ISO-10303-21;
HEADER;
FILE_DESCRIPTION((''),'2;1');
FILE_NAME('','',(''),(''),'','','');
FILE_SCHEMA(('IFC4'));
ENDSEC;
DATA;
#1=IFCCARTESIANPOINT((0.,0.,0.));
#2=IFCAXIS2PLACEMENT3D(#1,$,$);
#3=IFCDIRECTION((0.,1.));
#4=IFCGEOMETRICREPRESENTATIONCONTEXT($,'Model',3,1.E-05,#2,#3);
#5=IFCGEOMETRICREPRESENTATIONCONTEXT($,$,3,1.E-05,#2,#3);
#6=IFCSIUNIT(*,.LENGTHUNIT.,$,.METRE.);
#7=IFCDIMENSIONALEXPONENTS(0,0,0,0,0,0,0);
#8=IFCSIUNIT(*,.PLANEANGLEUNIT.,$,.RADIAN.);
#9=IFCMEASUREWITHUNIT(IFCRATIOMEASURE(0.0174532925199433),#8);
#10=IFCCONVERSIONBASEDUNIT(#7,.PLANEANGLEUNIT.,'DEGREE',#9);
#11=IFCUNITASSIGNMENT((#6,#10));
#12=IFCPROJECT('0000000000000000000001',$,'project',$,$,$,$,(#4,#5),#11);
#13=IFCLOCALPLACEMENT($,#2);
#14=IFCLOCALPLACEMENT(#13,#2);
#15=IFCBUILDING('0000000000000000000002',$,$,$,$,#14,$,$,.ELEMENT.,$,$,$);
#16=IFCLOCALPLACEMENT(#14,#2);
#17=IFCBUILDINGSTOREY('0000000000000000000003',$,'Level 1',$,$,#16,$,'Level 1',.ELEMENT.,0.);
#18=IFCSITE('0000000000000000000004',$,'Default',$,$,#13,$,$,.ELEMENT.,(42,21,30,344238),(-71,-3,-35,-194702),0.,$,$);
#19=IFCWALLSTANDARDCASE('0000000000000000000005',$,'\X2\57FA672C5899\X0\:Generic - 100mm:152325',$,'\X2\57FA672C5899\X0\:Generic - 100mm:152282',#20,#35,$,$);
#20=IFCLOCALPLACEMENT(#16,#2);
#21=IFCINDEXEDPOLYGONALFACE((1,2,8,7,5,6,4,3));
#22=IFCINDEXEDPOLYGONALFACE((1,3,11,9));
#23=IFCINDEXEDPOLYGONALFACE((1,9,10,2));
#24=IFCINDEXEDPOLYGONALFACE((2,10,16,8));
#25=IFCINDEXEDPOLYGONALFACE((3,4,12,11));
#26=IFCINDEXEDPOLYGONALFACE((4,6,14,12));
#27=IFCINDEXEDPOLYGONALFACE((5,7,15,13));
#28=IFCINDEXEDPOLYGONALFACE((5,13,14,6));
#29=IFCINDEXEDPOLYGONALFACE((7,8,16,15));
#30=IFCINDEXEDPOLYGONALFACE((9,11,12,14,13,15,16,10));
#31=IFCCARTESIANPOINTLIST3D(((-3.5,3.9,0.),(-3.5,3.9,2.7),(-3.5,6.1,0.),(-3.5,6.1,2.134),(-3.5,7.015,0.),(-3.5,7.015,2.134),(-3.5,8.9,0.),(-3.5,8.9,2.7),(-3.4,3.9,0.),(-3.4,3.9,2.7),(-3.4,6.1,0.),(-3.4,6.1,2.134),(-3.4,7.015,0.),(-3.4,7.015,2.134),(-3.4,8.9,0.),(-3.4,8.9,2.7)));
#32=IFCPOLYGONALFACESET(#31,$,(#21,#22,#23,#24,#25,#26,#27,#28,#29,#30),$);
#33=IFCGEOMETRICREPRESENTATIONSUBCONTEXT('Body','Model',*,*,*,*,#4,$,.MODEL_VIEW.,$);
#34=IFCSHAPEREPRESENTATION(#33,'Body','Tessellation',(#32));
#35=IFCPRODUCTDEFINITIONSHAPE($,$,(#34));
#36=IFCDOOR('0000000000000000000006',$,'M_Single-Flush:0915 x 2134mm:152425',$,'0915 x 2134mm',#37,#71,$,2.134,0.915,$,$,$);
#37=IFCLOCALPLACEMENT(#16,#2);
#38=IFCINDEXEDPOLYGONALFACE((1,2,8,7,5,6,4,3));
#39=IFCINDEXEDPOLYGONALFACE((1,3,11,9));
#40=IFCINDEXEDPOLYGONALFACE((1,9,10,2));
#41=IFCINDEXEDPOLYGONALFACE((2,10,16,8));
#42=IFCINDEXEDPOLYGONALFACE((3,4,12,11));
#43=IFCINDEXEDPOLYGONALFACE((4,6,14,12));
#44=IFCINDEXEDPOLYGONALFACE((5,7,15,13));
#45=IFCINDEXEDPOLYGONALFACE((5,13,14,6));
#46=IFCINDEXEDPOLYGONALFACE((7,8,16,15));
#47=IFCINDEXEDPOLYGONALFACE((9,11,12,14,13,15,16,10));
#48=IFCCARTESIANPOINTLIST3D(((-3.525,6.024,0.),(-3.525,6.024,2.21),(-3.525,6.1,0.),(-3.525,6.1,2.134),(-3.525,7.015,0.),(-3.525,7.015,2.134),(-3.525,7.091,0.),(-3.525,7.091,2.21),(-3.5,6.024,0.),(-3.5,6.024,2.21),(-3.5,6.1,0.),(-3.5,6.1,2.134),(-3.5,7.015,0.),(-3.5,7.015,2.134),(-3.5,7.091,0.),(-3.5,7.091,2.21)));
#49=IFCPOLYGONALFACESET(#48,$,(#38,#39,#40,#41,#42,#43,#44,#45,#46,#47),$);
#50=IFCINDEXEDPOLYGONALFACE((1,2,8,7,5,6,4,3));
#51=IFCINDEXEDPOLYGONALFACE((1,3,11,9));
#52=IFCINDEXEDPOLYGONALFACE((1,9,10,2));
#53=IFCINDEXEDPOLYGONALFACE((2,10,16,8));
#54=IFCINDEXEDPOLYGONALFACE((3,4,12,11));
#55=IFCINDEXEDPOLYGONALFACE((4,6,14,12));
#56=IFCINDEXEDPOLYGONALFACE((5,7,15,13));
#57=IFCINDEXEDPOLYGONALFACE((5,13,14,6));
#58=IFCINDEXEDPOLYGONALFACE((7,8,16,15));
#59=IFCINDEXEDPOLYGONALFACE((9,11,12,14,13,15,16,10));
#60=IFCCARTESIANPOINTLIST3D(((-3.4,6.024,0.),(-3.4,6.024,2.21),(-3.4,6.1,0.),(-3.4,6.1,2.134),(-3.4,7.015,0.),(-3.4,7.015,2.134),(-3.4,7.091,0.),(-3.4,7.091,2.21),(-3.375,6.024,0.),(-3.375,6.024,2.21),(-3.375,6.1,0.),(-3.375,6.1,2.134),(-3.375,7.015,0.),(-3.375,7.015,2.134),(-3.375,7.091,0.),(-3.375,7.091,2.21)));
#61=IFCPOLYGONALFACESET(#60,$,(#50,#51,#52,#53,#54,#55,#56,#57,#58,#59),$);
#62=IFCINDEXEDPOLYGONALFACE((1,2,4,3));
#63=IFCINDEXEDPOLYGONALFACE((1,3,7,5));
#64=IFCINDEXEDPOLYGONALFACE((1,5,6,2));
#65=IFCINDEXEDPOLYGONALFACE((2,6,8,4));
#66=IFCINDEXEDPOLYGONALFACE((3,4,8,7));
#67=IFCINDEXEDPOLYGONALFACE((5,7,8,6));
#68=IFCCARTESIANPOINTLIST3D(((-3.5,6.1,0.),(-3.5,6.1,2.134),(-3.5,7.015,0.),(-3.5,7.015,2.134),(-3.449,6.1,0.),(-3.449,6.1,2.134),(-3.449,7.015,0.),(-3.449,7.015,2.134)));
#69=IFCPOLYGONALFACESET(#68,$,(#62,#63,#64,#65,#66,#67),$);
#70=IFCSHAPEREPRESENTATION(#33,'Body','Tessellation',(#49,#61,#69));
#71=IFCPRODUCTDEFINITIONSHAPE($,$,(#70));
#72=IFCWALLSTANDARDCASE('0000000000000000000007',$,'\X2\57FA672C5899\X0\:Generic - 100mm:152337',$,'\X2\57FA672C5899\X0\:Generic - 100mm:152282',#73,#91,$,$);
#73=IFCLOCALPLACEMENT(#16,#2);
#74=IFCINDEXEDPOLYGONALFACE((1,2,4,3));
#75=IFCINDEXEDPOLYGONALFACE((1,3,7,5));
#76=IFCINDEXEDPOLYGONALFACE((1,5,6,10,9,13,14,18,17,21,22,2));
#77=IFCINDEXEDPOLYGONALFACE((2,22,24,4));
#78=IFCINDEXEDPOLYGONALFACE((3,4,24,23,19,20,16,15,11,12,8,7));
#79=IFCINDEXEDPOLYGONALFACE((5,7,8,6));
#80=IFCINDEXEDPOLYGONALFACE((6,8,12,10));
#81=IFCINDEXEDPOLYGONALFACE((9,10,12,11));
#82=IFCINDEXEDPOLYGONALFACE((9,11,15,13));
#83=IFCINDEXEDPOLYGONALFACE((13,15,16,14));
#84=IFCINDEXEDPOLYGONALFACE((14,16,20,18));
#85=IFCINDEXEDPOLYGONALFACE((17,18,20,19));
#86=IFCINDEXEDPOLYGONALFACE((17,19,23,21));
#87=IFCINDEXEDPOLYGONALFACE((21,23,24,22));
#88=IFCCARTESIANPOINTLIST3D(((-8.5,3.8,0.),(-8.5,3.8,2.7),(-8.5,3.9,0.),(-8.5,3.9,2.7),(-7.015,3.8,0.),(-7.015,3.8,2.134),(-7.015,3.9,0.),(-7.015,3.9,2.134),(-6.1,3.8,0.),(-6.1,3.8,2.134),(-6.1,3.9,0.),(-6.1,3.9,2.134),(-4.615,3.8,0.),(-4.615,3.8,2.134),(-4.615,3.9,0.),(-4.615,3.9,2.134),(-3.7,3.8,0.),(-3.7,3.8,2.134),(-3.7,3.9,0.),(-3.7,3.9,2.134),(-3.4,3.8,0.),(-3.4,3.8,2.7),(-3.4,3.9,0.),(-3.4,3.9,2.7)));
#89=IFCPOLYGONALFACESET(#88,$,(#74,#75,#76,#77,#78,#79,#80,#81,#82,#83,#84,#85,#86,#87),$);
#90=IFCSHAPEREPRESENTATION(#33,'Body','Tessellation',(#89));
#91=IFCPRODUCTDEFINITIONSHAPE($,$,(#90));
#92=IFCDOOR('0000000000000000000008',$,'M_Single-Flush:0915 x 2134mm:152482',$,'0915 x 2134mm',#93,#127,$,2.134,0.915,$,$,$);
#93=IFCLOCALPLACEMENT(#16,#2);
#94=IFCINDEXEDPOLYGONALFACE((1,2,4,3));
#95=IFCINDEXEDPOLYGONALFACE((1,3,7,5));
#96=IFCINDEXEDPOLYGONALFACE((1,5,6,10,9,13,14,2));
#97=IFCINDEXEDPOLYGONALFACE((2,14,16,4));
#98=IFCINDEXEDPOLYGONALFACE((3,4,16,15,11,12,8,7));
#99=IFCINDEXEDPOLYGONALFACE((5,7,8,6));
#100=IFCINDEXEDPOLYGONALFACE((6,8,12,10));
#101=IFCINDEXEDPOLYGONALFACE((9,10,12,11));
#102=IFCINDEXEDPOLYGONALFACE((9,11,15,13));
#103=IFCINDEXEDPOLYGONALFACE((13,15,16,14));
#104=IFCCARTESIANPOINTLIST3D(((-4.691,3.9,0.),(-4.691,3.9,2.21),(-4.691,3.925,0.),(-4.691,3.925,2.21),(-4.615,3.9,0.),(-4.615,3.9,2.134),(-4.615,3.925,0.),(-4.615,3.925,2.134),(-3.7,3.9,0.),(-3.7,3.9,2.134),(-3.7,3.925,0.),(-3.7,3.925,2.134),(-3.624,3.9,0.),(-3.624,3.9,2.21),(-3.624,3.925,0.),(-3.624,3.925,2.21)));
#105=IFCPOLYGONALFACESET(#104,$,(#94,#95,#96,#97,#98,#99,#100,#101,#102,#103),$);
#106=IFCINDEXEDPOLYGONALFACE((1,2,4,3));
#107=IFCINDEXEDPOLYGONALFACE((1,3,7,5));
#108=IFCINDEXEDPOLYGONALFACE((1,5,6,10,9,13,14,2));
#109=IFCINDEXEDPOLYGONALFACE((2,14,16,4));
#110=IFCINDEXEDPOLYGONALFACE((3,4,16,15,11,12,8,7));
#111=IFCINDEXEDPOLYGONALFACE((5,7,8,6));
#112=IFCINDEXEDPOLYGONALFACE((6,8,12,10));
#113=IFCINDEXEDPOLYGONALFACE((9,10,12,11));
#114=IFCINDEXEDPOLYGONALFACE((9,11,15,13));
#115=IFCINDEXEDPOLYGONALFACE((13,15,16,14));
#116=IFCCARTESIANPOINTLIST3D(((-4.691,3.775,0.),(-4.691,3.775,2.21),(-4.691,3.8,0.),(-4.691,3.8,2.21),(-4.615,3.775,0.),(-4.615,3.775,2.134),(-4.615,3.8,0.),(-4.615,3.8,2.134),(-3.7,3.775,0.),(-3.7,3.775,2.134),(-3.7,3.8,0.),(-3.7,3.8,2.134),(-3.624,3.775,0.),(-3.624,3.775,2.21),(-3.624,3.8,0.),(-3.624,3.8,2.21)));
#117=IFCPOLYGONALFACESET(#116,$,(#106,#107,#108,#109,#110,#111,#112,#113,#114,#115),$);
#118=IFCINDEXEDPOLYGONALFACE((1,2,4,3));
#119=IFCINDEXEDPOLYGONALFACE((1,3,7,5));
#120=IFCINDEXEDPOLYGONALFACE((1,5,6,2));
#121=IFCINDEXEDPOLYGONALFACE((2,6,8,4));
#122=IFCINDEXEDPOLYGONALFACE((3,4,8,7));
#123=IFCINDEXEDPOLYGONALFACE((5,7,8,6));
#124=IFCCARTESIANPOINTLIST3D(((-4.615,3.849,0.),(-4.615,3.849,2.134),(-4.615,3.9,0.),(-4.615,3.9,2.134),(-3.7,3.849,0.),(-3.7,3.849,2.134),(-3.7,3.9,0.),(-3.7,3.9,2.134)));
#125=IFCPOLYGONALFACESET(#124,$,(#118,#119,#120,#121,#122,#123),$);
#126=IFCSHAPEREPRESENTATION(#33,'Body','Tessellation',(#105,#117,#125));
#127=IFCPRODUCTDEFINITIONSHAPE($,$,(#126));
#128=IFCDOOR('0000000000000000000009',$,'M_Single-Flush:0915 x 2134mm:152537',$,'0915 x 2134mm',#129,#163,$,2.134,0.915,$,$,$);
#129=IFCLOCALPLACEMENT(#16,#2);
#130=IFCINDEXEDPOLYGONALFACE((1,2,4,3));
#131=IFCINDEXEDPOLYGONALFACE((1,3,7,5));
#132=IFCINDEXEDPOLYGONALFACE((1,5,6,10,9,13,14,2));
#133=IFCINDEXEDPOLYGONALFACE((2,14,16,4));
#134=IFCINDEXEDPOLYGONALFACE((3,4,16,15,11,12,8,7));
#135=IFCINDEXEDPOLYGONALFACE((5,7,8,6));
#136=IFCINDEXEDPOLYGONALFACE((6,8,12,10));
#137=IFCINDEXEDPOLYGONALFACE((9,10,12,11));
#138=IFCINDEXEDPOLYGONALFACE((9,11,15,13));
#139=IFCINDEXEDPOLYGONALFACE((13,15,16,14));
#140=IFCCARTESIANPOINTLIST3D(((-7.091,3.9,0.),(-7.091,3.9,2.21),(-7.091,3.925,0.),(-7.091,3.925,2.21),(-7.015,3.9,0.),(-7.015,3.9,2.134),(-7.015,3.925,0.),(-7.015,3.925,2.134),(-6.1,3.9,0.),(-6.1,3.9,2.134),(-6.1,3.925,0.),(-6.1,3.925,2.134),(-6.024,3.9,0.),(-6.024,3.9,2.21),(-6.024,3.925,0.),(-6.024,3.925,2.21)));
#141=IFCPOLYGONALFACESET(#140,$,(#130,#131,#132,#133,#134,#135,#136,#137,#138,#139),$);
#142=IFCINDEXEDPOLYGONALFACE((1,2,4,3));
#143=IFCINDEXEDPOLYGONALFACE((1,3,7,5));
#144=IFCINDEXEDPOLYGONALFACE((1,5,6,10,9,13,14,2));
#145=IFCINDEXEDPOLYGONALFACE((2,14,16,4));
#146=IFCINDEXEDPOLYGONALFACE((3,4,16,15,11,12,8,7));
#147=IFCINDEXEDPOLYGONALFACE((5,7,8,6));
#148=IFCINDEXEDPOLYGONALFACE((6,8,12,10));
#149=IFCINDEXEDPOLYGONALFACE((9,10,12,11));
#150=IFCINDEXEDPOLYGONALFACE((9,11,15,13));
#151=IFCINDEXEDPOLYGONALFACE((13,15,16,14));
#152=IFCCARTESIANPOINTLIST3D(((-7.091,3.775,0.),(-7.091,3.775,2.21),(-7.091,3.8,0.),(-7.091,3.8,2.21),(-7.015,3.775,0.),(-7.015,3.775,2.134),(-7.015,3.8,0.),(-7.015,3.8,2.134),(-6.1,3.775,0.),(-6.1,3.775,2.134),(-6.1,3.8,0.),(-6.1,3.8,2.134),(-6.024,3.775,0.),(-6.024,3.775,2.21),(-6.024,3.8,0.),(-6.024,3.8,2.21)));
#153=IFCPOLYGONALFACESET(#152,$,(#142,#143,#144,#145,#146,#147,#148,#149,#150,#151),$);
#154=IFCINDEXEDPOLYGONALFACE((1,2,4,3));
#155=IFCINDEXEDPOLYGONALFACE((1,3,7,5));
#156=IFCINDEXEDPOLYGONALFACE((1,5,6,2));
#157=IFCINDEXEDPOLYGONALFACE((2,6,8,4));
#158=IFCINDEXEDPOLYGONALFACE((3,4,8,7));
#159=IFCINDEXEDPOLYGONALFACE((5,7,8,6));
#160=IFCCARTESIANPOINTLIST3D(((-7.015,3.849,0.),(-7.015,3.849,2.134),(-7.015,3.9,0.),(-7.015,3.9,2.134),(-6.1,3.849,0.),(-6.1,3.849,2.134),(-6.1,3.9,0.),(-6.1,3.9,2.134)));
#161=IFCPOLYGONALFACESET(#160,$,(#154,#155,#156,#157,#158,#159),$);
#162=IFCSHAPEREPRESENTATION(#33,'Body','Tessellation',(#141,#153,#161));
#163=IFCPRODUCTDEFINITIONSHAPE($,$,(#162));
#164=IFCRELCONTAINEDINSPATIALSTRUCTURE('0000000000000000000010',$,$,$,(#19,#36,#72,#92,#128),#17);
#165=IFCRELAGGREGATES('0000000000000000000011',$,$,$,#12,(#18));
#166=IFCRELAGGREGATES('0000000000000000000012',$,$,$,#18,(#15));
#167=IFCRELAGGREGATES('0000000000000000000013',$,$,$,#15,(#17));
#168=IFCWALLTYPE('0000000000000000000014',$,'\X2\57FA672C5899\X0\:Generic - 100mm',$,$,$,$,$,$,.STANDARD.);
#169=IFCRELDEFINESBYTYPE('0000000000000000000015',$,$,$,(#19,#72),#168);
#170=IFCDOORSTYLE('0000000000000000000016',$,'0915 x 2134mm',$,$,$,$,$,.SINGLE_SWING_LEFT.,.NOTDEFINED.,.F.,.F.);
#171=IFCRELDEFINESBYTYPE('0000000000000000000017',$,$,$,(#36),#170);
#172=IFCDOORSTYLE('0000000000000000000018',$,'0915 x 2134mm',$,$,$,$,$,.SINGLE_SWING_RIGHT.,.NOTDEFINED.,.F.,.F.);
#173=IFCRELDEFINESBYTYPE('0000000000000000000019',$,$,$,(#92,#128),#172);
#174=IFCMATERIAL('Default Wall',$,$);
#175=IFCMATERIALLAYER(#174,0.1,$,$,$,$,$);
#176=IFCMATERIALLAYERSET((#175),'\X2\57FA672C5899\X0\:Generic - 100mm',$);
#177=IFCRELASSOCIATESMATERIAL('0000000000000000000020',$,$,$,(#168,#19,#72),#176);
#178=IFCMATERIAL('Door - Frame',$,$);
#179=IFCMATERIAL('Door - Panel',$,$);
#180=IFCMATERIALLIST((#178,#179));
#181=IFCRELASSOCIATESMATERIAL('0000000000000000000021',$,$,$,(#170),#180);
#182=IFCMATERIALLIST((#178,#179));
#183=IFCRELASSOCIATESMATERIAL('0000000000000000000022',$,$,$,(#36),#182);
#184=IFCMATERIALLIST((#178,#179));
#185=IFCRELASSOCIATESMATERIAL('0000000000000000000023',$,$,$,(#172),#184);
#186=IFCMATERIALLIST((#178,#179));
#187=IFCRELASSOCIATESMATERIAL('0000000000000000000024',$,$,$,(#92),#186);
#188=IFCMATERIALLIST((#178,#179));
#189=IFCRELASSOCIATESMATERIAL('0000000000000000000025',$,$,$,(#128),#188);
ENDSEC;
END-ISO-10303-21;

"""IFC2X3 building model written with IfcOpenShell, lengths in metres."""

from ifc_helpers import new_model, entity, si_unit, converted_unit, direction, frame, frame_2d, origin, origin_2d_with_axis, place, context, subcontext, project, spatial, polyline, rectangle, outline, extrude, clip, bounded_halfspace, source, transform, mapped, material, material_list, layer, layer_set, layer_usage, type_object, type_shapes, element, fill, save


model = new_model("IFC2X3")

# Units and contexts
model_context = context("Model", 3, precision=1e-05, world=origin(), true_north=direction((0.0, 1.0)))
context_of_model = context(None, 3, precision=1e-05, world=origin(), true_north=direction((0.0, 1.0)))
body_context = subcontext(model_context, "Body", "Model", "MODEL_VIEW")
ifc_project = project(units=[si_unit("LENGTHUNIT", "METRE"), converted_unit("PLANEANGLEUNIT", "DEGREE", entity("IfcRatioMeasure", 0.0174532925199433), si_unit("PLANEANGLEUNIT", "RADIAN"), dimensions=[0, 0, 0, 0, 0, 0, 0])], contexts=[model_context, context_of_model])

# Site, building, storey
site_placement = place(None, origin())
site = spatial("IfcSite", under=ifc_project, at=site_placement, Name="Default", CompositionType="ELEMENT", RefLatitude=(42, 21, 30, 344238), RefLongitude=(-71, -3, -35, -194702), RefElevation=0.0)
building_placement = place(site_placement, origin())
building = spatial("IfcBuilding", under=site, at=building_placement, CompositionType="ELEMENT")
storey_placement = place(building_placement, origin())
storey = spatial("IfcBuildingStorey", under=building, at=storey_placement, Name="Level 1", LongName="Level 1", CompositionType="ELEMENT", Elevation=0.0)

# Wall, opening, door
ifc_material_1 = material(Name="Default Wall")
ifc_layer_1 = layer(ifc_material_1, 0.1)
ifc_layer_set_1 = layer_set([ifc_layer_1], Name="基本墙:Generic - 100mm")
ifc_layer_usage_1 = layer_usage(ifc_layer_set_1, "AXIS2", "NEGATIVE", 0.05)
wall_type_1 = type_object("IfcWallType", Name="基本墙:Generic - 100mm", PredefinedType="STANDARD", material=ifc_layer_set_1)
wall_1_placement = place(storey_placement, frame((-3.45, 8.9, 0.0), z_axis=(0.0, 0.0, 1.0), x_axis=(0.0, -1.0, 0.0)))
wall_1 = element("IfcWallStandardCase", 1, at=wall_1_placement, inside=storey, type_object=wall_type_1, material=ifc_layer_usage_1, Name="基本墙:Generic - 100mm:152325", ObjectType="基本墙:Generic - 100mm:152282", context=body_context, shape_type="Clipping", body=[
    clip(extrude(rectangle(XDim=5.0, YDim=0.1, at=frame_2d((2.5, 0.0), x_axis=(-1.0, 0.0))), origin(), (0.0, 0.0, 1.0), 3.0), bounded_halfspace(frame((0.0, -0.05, 2.7), z_axis=(0.0, 0.0, -1.0), x_axis=(1.0, 0.0, 0.0)), True, frame((0.0, -0.05, 2.7), z_axis=(0.0, 0.0, -1.0), x_axis=(1.0, 0.0, 0.0)), polyline([(0.0, 0.0), (0.0, -0.1), (5.0, -0.1), (5.0, 0.0), (3.1, 0.0), (3.0, 0.0), (0.0, 0.0)]))),
])
opening_1_placement = place(wall_1_placement, frame((2.8, 0.05, 0.0)))
opening_1 = element("IfcOpeningElement", 2, at=opening_1_placement, cuts=wall_1, ObjectType="Opening", context=body_context, shape_type="SweptSolid", body=[
    extrude(rectangle(XDim=0.915, YDim=2.134, at=frame_2d((1.067, 0.4575), x_axis=(0.0, -1.0))), frame((0.0, 0.0, 0.0), z_axis=(0.0, -1.0, 0.0), x_axis=(0.0, 0.0, 1.0)), (0.0, 0.0, 1.0), 0.1),
])
ifc_material_2 = material(Name="Door - Frame")
ifc_material_3 = material(Name="Door - Panel")
ifc_material_list_1 = material_list([ifc_material_2, ifc_material_3])
ifc_material_list_2 = material_list([ifc_material_2, ifc_material_3])
door_style_1 = type_object("IfcDoorStyle", Name="0915 x 2134mm", ConstructionType="NOTDEFINED", OperationType="SINGLE_SWING_LEFT", ParameterTakesPrecedence=False, Sizeable=False, material=ifc_material_list_2)
shared_shape_1 = source(origin(), body_context, "Body", "SweptSolid", [
    extrude(outline(polyline([(-0.5335, -1.124), (0.5335, -1.124), (0.5335, 1.086), (0.4575, 1.086), (0.4575, -1.048), (-0.4575, -1.048), (-0.4575, 1.086), (-0.5335, 1.086), (-0.5335, -1.124)])), frame((0.4575, 0.125, 1.086), z_axis=(0.0, -1.0, 0.0), x_axis=(-1.0, 0.0, 0.0)), (0.0, 0.0, 1.0), 0.025),
    extrude(outline(polyline([(-1.124, -0.5335), (1.086, -0.5335), (1.086, -0.4575), (-1.048, -0.4575), (-1.048, 0.4575), (1.086, 0.4575), (1.086, 0.5335), (-1.124, 0.5335), (-1.124, -0.5335)])), frame((0.4575, 0.0, 1.086), z_axis=(0.0, -1.0, 0.0), x_axis=(0.0, 0.0, -1.0)), (0.0, 0.0, 1.0), 0.025),
    extrude(rectangle(XDim=0.915, YDim=0.051, at=origin_2d_with_axis()), frame((0.4575, 0.0745, 0.0)), (0.0, 0.0, 1.0), 2.134),
])
type_shapes(door_style_1, [shared_shape_1])
door_1_placement = place(opening_1_placement, frame((0.0, 0.0, 0.0), z_axis=(0.0, 0.0, 1.0), x_axis=(-1.0, 0.0, 0.0)))
door_1 = element("IfcDoor", 3, at=door_1_placement, inside=storey, type_object=door_style_1, material=ifc_material_list_1, Name="M_Single-Flush:0915 x 2134mm:152425", ObjectType="0915 x 2134mm", OverallHeight=2.134, OverallWidth=0.915, context=body_context, shape_type="MappedRepresentation", body=[
    mapped(shared_shape_1, transform((0.0, 0.0, 0.0), scale=1.0)),
])
fill(opening_1, door_1)

# Wall, openings, doors
ifc_layer_usage_2 = layer_usage(ifc_layer_set_1, "AXIS2", "NEGATIVE", 0.05)
wall_2_placement = place(storey_placement, frame((-3.4, 3.85, 0.0), z_axis=(0.0, 0.0, 1.0), x_axis=(-1.0, 0.0, 0.0)))
wall_2 = element("IfcWallStandardCase", 4, at=wall_2_placement, inside=storey, type_object=wall_type_1, material=ifc_layer_usage_2, Name="基本墙:Generic - 100mm:152337", ObjectType="基本墙:Generic - 100mm:152282", context=body_context, shape_type="Clipping", body=[
    clip(extrude(rectangle(XDim=5.1, YDim=0.1, at=frame_2d((2.55, 0.0), x_axis=(-1.0, 0.0))), origin(), (0.0, 0.0, 1.0), 3.0), bounded_halfspace(frame((0.0, -0.05, 2.7), z_axis=(0.0, 0.0, -1.0), x_axis=(0.0, 1.0, 0.0)), True, frame((0.0, -0.05, 2.7), z_axis=(0.0, 0.0, -1.0), x_axis=(0.0, 1.0, 0.0)), polyline([(0.0, 0.0), (0.1, 0.0), (0.1, 5.1), (0.0, 5.1), (0.0, 2.6), (0.0, 2.5), (0.0, 0.1), (0.0, 0.0)]))),
])
opening_2_placement = place(wall_2_placement, frame((1.215, 0.05, 0.0)))
opening_2 = element("IfcOpeningElement", 5, at=opening_2_placement, cuts=wall_2, ObjectType="Opening", context=body_context, shape_type="SweptSolid", body=[
    extrude(rectangle(XDim=0.915, YDim=2.134, at=frame_2d((1.067, 0.4575), x_axis=(0.0, 1.0))), frame((0.0, 0.0, 0.0), z_axis=(0.0, -1.0, 0.0), x_axis=(0.0, 0.0, 1.0)), (0.0, 0.0, 1.0), 0.1),
])
opening_3_placement = place(wall_2_placement, frame((3.615, 0.05, 0.0)))
opening_3 = element("IfcOpeningElement", 6, at=opening_3_placement, cuts=wall_2, ObjectType="Opening", context=body_context, shape_type="SweptSolid", body=[
    extrude(rectangle(XDim=0.915, YDim=2.134, at=frame_2d((1.067, 0.4575), x_axis=(0.0, 1.0))), frame((0.0, 0.0, 0.0), z_axis=(0.0, -1.0, 0.0), x_axis=(0.0, 0.0, 1.0)), (0.0, 0.0, 1.0), 0.1),
])
ifc_material_list_3 = material_list([ifc_material_2, ifc_material_3])
ifc_material_list_4 = material_list([ifc_material_2, ifc_material_3])
door_style_2 = type_object("IfcDoorStyle", Name="0915 x 2134mm", ConstructionType="NOTDEFINED", OperationType="SINGLE_SWING_RIGHT", ParameterTakesPrecedence=False, Sizeable=False, material=ifc_material_list_4)
shared_shape_2 = source(origin(), body_context, "Body", "SweptSolid", [
    extrude(outline(polyline([(-0.5335, -1.124), (0.5335, -1.124), (0.5335, 1.086), (0.4575, 1.086), (0.4575, -1.048), (-0.4575, -1.048), (-0.4575, 1.086), (-0.5335, 1.086), (-0.5335, -1.124)])), frame((0.4575, 0.1, 1.086), z_axis=(0.0, 1.0, 0.0), x_axis=(1.0, 0.0, 0.0)), (0.0, 0.0, 1.0), 0.025),
    extrude(outline(polyline([(-1.124, -0.5335), (1.086, -0.5335), (1.086, -0.4575), (-1.048, -0.4575), (-1.048, 0.4575), (1.086, 0.4575), (1.086, 0.5335), (-1.124, 0.5335), (-1.124, -0.5335)])), frame((0.4575, -0.025, 1.086), z_axis=(0.0, 1.0, 0.0), x_axis=(0.0, 0.0, -1.0)), (0.0, 0.0, 1.0), 0.025),
    extrude(rectangle(XDim=0.051, YDim=0.915, at=origin_2d_with_axis()), frame((0.4575, 0.0745, 0.0), z_axis=(0.0, 0.0, 1.0), x_axis=(0.0, 1.0, 0.0)), (0.0, 0.0, 1.0), 2.134),
])
type_shapes(door_style_2, [shared_shape_2])
door_2_placement = place(opening_2_placement, frame((0.0, 0.0, 0.0), z_axis=(0.0, 0.0, 1.0), x_axis=(-1.0, 0.0, 0.0)))
door_2 = element("IfcDoor", 7, at=door_2_placement, inside=storey, type_object=door_style_2, material=ifc_material_list_3, Name="M_Single-Flush:0915 x 2134mm:152482", ObjectType="0915 x 2134mm", OverallHeight=2.134, OverallWidth=0.915, context=body_context, shape_type="MappedRepresentation", body=[
    mapped(shared_shape_2, transform((0.0, 0.0, 0.0), scale=1.0)),
])
fill(opening_2, door_2)
ifc_material_list_5 = material_list([ifc_material_2, ifc_material_3])
door_3_placement = place(opening_3_placement, frame((0.0, 0.0, 0.0), z_axis=(0.0, 0.0, 1.0), x_axis=(-1.0, 0.0, 0.0)))
door_3 = element("IfcDoor", 8, at=door_3_placement, inside=storey, type_object=door_style_2, material=ifc_material_list_5, Name="M_Single-Flush:0915 x 2134mm:152537", ObjectType="0915 x 2134mm", OverallHeight=2.134, OverallWidth=0.915, context=body_context, shape_type="MappedRepresentation", body=[
    mapped(shared_shape_2, transform((0.0, 0.0, 0.0), scale=1.0)),
])
fill(opening_3, door_3)

save(model, "model.ifc")
